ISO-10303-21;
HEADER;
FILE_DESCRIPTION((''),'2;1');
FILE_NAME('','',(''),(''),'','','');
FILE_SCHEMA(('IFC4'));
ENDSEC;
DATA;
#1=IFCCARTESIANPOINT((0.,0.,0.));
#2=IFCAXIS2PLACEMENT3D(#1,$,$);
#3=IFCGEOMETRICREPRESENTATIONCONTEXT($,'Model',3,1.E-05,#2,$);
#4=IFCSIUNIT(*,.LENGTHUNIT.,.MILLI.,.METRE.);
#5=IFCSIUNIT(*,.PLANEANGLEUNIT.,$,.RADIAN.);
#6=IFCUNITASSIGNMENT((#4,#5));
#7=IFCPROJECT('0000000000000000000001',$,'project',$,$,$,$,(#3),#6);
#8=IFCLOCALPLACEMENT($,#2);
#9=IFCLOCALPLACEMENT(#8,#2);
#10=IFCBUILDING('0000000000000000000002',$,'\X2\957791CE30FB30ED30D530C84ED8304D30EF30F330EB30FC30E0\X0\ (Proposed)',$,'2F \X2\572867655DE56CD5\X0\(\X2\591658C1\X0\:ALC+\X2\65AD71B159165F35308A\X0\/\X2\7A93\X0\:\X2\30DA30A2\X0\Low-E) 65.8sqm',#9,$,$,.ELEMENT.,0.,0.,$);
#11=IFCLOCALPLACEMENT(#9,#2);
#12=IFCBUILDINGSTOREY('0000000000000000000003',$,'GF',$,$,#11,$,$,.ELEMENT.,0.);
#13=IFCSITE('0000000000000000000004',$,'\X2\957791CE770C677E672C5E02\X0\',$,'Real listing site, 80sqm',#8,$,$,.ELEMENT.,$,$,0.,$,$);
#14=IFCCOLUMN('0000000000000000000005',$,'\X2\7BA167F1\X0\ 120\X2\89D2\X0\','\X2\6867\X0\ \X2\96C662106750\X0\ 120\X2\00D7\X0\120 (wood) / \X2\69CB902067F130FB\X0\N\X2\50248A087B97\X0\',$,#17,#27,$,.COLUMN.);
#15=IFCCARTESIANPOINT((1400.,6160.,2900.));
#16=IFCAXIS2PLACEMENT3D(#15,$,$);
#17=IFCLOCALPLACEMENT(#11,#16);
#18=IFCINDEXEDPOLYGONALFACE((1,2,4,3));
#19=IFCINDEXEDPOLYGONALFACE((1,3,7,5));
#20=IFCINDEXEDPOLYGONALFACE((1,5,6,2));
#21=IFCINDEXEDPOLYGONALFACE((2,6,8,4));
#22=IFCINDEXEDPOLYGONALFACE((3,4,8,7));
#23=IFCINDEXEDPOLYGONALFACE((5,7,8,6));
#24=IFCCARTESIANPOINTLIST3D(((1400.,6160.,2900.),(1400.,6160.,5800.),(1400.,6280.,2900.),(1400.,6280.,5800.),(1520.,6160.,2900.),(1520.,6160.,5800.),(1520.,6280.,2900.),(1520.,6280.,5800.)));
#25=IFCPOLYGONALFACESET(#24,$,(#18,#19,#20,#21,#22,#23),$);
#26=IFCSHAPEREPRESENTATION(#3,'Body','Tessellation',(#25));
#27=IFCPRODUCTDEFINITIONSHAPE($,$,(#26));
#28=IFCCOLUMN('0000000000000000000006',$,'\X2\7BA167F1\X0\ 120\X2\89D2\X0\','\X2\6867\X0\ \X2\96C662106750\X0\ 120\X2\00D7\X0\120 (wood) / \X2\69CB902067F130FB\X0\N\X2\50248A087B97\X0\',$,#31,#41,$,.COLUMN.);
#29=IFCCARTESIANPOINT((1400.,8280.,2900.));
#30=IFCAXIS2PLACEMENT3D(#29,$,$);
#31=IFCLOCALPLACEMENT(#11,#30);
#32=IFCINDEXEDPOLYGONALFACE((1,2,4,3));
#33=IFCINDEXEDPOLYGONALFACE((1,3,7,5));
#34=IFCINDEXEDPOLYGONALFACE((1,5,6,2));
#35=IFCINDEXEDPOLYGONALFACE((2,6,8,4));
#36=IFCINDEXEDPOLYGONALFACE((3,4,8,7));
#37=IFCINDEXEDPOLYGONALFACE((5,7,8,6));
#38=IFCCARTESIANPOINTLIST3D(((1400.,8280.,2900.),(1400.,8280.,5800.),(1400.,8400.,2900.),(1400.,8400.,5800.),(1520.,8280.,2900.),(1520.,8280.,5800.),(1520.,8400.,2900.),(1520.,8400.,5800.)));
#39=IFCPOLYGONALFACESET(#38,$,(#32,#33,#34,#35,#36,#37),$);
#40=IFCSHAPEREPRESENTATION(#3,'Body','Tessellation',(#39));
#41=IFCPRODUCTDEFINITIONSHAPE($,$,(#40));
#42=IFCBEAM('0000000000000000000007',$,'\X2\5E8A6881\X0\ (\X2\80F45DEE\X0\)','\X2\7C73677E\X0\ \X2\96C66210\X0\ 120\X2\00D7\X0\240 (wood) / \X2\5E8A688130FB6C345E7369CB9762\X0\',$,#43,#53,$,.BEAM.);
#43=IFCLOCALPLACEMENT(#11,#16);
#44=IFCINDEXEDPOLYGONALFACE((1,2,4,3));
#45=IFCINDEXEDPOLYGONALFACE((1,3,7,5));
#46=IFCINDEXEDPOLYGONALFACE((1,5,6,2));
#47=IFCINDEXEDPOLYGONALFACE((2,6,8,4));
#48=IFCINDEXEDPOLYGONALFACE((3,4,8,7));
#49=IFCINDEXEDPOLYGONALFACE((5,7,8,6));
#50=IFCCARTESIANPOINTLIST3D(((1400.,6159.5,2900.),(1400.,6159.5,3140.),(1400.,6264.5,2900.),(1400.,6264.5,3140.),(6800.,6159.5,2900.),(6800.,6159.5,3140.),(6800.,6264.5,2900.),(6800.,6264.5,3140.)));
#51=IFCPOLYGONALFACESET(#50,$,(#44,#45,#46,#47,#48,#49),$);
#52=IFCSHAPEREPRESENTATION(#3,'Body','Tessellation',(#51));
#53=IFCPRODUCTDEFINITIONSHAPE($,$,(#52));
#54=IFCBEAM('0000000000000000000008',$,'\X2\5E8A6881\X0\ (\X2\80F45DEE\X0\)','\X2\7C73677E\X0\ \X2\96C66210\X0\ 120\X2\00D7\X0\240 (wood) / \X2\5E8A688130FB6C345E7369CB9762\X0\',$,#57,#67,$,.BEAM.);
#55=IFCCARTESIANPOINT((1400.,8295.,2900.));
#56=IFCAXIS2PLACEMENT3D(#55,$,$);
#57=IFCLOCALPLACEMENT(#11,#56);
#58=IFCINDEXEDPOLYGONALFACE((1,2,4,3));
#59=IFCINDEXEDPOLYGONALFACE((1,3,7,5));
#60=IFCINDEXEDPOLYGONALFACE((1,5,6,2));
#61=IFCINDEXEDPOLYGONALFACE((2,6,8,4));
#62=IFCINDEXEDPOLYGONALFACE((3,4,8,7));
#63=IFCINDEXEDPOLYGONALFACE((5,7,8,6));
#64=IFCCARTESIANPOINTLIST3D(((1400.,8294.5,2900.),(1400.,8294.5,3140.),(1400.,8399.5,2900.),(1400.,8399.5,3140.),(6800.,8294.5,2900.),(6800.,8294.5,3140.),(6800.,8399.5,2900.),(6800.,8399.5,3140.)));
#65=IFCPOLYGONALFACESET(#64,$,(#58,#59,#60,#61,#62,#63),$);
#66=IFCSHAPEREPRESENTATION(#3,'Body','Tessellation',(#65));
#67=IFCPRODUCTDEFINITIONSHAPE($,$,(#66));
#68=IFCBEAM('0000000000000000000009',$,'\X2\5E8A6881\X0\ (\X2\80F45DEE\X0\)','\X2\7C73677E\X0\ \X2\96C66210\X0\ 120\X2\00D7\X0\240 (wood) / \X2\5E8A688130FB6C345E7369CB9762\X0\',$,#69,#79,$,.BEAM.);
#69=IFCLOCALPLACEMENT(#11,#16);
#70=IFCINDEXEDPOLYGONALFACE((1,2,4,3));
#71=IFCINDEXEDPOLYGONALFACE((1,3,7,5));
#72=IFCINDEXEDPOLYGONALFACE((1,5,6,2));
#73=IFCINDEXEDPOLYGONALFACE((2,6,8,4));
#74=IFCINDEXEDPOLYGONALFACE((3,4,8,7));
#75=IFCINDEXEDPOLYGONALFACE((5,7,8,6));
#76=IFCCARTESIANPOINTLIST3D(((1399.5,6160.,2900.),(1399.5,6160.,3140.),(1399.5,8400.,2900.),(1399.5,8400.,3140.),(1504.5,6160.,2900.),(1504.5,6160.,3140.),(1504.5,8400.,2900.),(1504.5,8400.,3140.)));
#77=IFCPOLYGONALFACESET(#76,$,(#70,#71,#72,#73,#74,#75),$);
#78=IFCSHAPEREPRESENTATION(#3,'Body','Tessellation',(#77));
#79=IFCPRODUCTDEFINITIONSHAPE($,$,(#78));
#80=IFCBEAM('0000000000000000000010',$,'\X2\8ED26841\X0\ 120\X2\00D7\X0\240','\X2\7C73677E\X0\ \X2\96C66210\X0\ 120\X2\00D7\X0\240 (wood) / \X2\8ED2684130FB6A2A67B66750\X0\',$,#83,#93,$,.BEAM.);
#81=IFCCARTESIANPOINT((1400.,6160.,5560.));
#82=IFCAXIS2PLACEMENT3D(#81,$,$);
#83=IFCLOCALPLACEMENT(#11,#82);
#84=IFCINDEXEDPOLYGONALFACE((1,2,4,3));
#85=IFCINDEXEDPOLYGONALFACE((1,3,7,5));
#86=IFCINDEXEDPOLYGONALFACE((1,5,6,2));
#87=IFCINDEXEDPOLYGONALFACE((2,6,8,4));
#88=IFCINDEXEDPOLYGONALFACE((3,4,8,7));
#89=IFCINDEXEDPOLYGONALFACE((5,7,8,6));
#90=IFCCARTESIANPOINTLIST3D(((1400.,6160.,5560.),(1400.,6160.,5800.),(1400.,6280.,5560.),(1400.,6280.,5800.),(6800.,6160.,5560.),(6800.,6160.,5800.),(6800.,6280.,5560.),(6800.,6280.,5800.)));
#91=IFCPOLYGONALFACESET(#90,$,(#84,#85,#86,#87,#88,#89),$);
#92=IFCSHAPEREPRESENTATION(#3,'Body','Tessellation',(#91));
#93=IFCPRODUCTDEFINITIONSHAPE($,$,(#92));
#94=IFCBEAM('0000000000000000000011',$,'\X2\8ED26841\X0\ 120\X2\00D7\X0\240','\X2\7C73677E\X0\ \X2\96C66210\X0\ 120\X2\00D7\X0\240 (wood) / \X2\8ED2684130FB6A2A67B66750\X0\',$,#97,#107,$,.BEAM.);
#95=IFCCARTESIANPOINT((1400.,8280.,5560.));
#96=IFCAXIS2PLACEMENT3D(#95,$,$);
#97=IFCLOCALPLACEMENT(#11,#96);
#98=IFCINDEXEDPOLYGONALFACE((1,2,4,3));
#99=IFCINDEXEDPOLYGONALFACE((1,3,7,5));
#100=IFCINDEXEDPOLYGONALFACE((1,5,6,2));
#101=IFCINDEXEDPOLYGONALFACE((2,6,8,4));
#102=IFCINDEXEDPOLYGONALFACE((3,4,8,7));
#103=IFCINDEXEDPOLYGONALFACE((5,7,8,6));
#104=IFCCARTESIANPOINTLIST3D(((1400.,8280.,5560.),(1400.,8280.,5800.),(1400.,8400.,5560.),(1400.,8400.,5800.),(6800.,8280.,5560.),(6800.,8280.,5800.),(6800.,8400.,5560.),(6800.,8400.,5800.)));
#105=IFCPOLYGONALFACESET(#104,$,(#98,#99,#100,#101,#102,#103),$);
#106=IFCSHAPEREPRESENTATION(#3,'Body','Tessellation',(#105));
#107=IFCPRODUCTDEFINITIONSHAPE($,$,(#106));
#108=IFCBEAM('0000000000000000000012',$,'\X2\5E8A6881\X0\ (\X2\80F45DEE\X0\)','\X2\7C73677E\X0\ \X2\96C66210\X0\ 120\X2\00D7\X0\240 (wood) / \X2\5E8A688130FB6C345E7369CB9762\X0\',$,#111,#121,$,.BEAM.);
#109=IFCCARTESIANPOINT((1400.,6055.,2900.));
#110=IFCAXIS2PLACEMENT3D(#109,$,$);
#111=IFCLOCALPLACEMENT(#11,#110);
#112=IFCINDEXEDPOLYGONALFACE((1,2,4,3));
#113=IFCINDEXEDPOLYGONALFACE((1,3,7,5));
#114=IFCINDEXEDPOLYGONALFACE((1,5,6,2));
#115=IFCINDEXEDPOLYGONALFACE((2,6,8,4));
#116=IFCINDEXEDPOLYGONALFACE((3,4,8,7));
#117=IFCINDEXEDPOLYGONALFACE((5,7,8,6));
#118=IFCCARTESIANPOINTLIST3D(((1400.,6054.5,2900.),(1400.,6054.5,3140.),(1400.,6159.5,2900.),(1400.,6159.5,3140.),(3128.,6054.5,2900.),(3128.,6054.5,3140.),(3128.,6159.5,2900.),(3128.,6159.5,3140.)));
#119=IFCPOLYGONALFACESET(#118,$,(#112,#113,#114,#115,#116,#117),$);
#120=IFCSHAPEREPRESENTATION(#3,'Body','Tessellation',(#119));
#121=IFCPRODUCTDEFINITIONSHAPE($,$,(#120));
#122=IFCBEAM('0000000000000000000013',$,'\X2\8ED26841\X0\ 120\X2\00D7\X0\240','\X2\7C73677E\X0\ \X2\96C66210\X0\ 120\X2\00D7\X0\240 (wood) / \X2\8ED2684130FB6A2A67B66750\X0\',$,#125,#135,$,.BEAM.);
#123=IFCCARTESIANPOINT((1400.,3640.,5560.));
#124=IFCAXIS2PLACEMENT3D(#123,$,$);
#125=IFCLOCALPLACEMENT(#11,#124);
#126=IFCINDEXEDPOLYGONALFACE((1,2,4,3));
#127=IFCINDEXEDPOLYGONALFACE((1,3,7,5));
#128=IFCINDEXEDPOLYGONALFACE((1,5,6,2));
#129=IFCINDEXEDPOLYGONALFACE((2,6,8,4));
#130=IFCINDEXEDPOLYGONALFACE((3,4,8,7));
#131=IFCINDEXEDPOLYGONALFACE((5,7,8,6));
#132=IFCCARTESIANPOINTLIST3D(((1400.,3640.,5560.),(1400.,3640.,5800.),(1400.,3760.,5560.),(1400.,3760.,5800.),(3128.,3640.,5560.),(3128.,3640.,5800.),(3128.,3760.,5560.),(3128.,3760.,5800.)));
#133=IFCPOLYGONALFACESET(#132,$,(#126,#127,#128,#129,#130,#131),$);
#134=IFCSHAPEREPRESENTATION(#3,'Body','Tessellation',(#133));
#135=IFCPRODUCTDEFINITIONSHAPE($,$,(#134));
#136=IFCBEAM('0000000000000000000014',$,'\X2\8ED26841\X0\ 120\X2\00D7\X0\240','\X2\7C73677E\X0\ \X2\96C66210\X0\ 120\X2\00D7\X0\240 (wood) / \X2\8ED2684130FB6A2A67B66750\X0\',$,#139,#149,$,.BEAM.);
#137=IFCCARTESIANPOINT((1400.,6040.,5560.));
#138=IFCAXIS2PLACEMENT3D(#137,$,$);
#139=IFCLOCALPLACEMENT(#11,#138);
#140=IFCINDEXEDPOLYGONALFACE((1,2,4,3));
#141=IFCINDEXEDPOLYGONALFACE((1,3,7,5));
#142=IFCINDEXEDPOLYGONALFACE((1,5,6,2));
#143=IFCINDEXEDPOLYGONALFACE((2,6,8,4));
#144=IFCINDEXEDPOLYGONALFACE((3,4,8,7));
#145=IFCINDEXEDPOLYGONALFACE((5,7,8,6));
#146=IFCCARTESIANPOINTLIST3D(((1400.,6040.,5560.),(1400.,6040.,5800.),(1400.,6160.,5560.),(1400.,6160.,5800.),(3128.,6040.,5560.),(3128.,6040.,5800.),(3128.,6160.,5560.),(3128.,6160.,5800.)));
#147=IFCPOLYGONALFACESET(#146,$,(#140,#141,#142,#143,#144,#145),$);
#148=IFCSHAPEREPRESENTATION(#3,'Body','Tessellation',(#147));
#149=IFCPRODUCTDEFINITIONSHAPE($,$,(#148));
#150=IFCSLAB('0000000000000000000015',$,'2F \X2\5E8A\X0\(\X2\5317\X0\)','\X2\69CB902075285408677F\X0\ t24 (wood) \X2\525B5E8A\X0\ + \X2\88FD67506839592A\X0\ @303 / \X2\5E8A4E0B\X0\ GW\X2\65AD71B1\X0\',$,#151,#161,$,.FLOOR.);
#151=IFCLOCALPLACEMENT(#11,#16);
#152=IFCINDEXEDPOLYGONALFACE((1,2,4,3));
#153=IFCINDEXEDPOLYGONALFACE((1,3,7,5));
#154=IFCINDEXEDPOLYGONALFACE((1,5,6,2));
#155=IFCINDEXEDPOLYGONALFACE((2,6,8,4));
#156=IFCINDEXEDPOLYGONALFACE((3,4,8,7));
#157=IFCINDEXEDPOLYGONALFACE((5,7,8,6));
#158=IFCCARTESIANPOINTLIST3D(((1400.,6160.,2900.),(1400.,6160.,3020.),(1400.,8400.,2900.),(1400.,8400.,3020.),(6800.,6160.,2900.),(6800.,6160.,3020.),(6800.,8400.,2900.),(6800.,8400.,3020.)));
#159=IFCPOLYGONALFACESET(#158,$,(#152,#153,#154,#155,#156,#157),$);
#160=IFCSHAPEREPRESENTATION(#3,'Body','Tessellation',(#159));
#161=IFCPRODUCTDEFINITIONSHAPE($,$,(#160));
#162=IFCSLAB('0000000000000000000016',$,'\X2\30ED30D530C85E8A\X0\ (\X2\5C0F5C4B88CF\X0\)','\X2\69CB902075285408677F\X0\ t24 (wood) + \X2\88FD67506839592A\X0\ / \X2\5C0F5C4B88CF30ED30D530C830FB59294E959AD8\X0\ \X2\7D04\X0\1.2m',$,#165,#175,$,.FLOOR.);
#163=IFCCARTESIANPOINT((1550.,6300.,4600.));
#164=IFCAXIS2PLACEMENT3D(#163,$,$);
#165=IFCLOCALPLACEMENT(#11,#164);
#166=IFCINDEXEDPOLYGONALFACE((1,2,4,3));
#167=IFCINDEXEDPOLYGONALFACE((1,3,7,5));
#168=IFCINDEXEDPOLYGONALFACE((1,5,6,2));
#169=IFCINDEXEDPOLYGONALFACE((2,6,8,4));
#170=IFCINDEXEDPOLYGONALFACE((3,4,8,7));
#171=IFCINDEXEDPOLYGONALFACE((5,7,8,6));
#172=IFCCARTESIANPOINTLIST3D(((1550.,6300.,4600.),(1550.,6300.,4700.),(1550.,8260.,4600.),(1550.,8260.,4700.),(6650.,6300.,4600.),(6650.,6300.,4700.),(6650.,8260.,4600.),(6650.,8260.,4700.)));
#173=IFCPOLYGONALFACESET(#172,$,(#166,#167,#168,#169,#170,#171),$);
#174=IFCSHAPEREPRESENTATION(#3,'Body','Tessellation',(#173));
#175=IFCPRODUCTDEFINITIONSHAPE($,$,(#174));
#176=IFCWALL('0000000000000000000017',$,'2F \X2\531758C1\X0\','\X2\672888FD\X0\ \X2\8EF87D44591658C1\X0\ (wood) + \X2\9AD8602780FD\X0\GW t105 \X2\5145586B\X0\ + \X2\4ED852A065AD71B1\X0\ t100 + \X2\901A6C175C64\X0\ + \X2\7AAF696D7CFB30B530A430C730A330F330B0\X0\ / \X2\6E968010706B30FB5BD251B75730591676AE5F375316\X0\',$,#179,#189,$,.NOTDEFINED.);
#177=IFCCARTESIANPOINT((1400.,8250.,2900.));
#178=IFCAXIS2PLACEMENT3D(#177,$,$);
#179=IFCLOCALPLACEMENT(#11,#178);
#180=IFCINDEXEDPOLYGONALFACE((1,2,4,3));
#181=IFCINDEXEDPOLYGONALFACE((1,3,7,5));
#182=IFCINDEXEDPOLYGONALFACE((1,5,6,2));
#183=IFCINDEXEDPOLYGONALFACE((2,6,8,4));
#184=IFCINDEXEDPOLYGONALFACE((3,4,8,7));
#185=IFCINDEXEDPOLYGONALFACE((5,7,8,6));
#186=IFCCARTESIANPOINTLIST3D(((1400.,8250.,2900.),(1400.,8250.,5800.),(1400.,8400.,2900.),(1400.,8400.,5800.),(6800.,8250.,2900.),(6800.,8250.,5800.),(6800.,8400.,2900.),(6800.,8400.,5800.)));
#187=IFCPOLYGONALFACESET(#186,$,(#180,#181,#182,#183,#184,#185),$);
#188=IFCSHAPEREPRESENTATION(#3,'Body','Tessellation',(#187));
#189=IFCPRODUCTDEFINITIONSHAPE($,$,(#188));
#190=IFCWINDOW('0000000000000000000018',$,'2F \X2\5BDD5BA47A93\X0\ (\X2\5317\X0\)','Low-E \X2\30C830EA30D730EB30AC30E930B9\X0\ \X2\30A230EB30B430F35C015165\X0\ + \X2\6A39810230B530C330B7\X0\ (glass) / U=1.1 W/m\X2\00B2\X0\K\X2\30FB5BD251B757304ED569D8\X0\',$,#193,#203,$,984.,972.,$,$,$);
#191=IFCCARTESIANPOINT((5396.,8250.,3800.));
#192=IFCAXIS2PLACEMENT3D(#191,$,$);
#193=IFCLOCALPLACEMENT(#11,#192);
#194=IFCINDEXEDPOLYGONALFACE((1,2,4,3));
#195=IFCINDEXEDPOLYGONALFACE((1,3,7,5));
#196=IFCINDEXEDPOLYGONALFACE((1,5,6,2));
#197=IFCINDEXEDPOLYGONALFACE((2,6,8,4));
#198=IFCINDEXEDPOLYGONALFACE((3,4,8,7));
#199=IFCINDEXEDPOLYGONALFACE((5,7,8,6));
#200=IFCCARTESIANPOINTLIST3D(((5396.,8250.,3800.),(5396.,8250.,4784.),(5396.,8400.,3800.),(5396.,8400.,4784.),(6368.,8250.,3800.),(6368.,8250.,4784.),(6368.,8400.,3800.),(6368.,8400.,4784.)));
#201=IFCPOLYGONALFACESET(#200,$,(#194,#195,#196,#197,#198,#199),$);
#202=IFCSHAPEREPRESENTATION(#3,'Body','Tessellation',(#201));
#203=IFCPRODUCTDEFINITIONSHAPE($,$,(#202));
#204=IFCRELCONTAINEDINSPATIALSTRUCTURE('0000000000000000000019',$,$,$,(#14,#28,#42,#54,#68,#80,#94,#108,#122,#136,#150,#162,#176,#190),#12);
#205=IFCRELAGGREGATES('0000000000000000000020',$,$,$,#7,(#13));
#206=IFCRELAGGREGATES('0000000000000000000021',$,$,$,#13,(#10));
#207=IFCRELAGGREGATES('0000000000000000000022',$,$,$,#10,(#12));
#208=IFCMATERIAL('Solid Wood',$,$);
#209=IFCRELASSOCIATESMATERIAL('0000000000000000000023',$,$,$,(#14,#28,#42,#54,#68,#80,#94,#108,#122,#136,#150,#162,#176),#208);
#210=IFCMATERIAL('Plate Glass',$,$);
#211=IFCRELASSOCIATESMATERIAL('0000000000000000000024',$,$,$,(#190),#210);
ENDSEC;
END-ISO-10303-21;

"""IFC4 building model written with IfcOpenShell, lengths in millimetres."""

from ifc_helpers import new_model, si_unit, frame, frame_2d, origin, place, context, project, spatial, rectangle, extrude, material, element, fill, save


model = new_model("IFC4")

# Units and contexts
model_context = context("Model", 3, precision=1e-05, world=origin())
ifc_project = project(units=[si_unit("LENGTHUNIT", "METRE", prefix="MILLI"), si_unit("PLANEANGLEUNIT", "RADIAN")], contexts=[model_context])

# Site, building, storey
site_placement = place(None, origin())
site = spatial("IfcSite", under=ifc_project, at=site_placement, Name="長野県松本市", ObjectType="Real listing site, 80sqm", CompositionType="ELEMENT", RefElevation=0.0)
building_placement = place(site_placement, origin())
building = spatial("IfcBuilding", under=site, at=building_placement, Name="長野・ロフト付きワンルーム (Proposed)", ObjectType="2F 在来工法(外壁:ALC+断熱外張り/窓:ペアLow-E) 65.8sqm", CompositionType="ELEMENT", ElevationOfRefHeight=0.0, ElevationOfTerrain=0.0)
storey_placement = place(building_placement, origin())
storey = spatial("IfcBuildingStorey", under=building, at=storey_placement, Name="GF", CompositionType="ELEMENT", Elevation=0.0)

# Columns
ifc_material_1 = material(Name="Solid Wood")
column_1_placement = place(storey_placement, frame((1400.0, 6160.0, 2900.0)))
element("IfcColumn", 1, at=column_1_placement, inside=storey, material=ifc_material_1, Name="管柱 120角", Description="桧 集成材 120×120 (wood) / 構造柱・N値計算", PredefinedType="COLUMN", context=model_context, shape_type="SweptSolid", body=[
    extrude(rectangle(XDim=120.0, YDim=120.0, at=frame_2d((60.0, 60.0))), frame((1400.0, 6160.0, 2900.0)), (0.0, 0.0, 1.0), 2900.0),
])
column_2_placement = place(storey_placement, frame((1400.0, 8280.0, 2900.0)))
element("IfcColumn", 2, at=column_2_placement, inside=storey, material=ifc_material_1, Name="管柱 120角", Description="桧 集成材 120×120 (wood) / 構造柱・N値計算", PredefinedType="COLUMN", context=model_context, shape_type="SweptSolid", body=[
    extrude(rectangle(XDim=120.0, YDim=120.0, at=frame_2d((60.0, 60.0))), frame((1400.0, 8280.0, 2900.0)), (0.0, 0.0, 1.0), 2900.0),
])

# Beams
beam_1_placement = place(storey_placement, frame((1400.0, 6160.0, 2900.0)))
element("IfcBeam", 3, at=beam_1_placement, inside=storey, material=ifc_material_1, Name="床梁 (胴差)", Description="米松 集成 120×240 (wood) / 床梁・水平構面", PredefinedType="BEAM", context=model_context, shape_type="SweptSolid", body=[
    extrude(rectangle(XDim=5400.0, YDim=105.0, at=frame_2d((2700.0, 52.0))), frame((1400.0, 6160.0, 2900.0)), (0.0, 0.0, 1.0), 240.0),
])
beam_2_placement = place(storey_placement, frame((1400.0, 8295.0, 2900.0)))
element("IfcBeam", 4, at=beam_2_placement, inside=storey, material=ifc_material_1, Name="床梁 (胴差)", Description="米松 集成 120×240 (wood) / 床梁・水平構面", PredefinedType="BEAM", context=model_context, shape_type="SweptSolid", body=[
    extrude(rectangle(XDim=5400.0, YDim=105.0, at=frame_2d((2700.0, 52.0))), frame((1400.0, 8295.0, 2900.0)), (0.0, 0.0, 1.0), 240.0),
])
beam_3_placement = place(storey_placement, frame((1400.0, 6160.0, 2900.0)))
element("IfcBeam", 5, at=beam_3_placement, inside=storey, material=ifc_material_1, Name="床梁 (胴差)", Description="米松 集成 120×240 (wood) / 床梁・水平構面", PredefinedType="BEAM", context=model_context, shape_type="SweptSolid", body=[
    extrude(rectangle(XDim=105.0, YDim=2240.0, at=frame_2d((52.0, 1120.0))), frame((1400.0, 6160.0, 2900.0)), (0.0, 0.0, 1.0), 240.0),
])
beam_4_placement = place(storey_placement, frame((1400.0, 6160.0, 5560.0)))
element("IfcBeam", 6, at=beam_4_placement, inside=storey, material=ifc_material_1, Name="軒桁 120×240", Description="米松 集成 120×240 (wood) / 軒桁・横架材", PredefinedType="BEAM", context=model_context, shape_type="SweptSolid", body=[
    extrude(rectangle(XDim=5400.0, YDim=120.0, at=frame_2d((2700.0, 60.0))), frame((1400.0, 6160.0, 5560.0)), (0.0, 0.0, 1.0), 240.0),
])
beam_5_placement = place(storey_placement, frame((1400.0, 8280.0, 5560.0)))
element("IfcBeam", 7, at=beam_5_placement, inside=storey, material=ifc_material_1, Name="軒桁 120×240", Description="米松 集成 120×240 (wood) / 軒桁・横架材", PredefinedType="BEAM", context=model_context, shape_type="SweptSolid", body=[
    extrude(rectangle(XDim=5400.0, YDim=120.0, at=frame_2d((2700.0, 60.0))), frame((1400.0, 8280.0, 5560.0)), (0.0, 0.0, 1.0), 240.0),
])
beam_6_placement = place(storey_placement, frame((1400.0, 6055.0, 2900.0)))
element("IfcBeam", 8, at=beam_6_placement, inside=storey, material=ifc_material_1, Name="床梁 (胴差)", Description="米松 集成 120×240 (wood) / 床梁・水平構面", PredefinedType="BEAM", context=model_context, shape_type="SweptSolid", body=[
    extrude(rectangle(XDim=1728.0, YDim=105.0, at=frame_2d((864.0, 52.0))), frame((1400.0, 6055.0, 2900.0)), (0.0, 0.0, 1.0), 240.0),
])
beam_7_placement = place(storey_placement, frame((1400.0, 3640.0, 5560.0)))
element("IfcBeam", 9, at=beam_7_placement, inside=storey, material=ifc_material_1, Name="軒桁 120×240", Description="米松 集成 120×240 (wood) / 軒桁・横架材", PredefinedType="BEAM", context=model_context, shape_type="SweptSolid", body=[
    extrude(rectangle(XDim=1728.0, YDim=120.0, at=frame_2d((864.0, 60.0))), frame((1400.0, 3640.0, 5560.0)), (0.0, 0.0, 1.0), 240.0),
])
beam_8_placement = place(storey_placement, frame((1400.0, 6040.0, 5560.0)))
element("IfcBeam", 10, at=beam_8_placement, inside=storey, material=ifc_material_1, Name="軒桁 120×240", Description="米松 集成 120×240 (wood) / 軒桁・横架材", PredefinedType="BEAM", context=model_context, shape_type="SweptSolid", body=[
    extrude(rectangle(XDim=1728.0, YDim=120.0, at=frame_2d((864.0, 60.0))), frame((1400.0, 6040.0, 5560.0)), (0.0, 0.0, 1.0), 240.0),
])

# Slabs
slab_1_placement = place(storey_placement, frame((1400.0, 6160.0, 2900.0)))
element("IfcSlab", 11, at=slab_1_placement, inside=storey, material=ifc_material_1, Name="2F 床(北)", Description="構造用合板 t24 (wood) 剛床 + 製材根太 @303 / 床下 GW断熱", PredefinedType="FLOOR", context=model_context, shape_type="SweptSolid", body=[
    extrude(rectangle(XDim=5400.0, YDim=2240.0, at=frame_2d((2700.0, 1120.0))), frame((1400.0, 6160.0, 2900.0)), (0.0, 0.0, 1.0), 120.0),
])
slab_2_placement = place(storey_placement, frame((1550.0, 6300.0, 4600.0)))
element("IfcSlab", 12, at=slab_2_placement, inside=storey, material=ifc_material_1, Name="ロフト床 (小屋裏)", Description="構造用合板 t24 (wood) + 製材根太 / 小屋裏ロフト・天井高 約1.2m", PredefinedType="FLOOR", context=model_context, shape_type="SweptSolid", body=[
    extrude(rectangle(XDim=5100.0, YDim=1960.0, at=frame_2d((2550.0, 980.0))), frame((1550.0, 6300.0, 4600.0)), (0.0, 0.0, 1.0), 100.0),
])

# Wall, opening, window
wall_placement = place(storey_placement, frame((1400.0, 8250.0, 2900.0)))
wall = element("IfcWall", 13, at=wall_placement, inside=storey, material=ifc_material_1, Name="2F 北壁", Description="木製 軸組外壁 (wood) + 高性能GW t105 充填 + 付加断熱 t100 + 通気層 + 窯業系サイディング / 準耐火・寒冷地外皮強化", PredefinedType="NOTDEFINED", context=model_context, shape_type="SweptSolid", body=[
    extrude(rectangle(XDim=5400.0, YDim=150.0, at=frame_2d((2700.0, 75.0))), frame((1400.0, 8250.0, 2900.0)), (0.0, 0.0, 1.0), 2900.0),
])
opening_placement = place(storey_placement, frame((5396.0, 8250.0, 3800.0)))
opening = element("IfcOpeningElement", 14, at=opening_placement, cuts=wall, PredefinedType="NOTDEFINED", context=model_context, shape_type="SweptSolid", body=[
    extrude(rectangle(XDim=972.0, YDim=150.0, at=frame_2d((486.0, 75.0))), frame((5396.0, 8250.0, 3800.0)), (0.0, 0.0, 1.0), 984.0),
])
ifc_material_2 = material(Name="Plate Glass")
window_placement = place(storey_placement, frame((5396.0, 8250.0, 3800.0)))
window = element("IfcWindow", 15, at=window_placement, inside=storey, material=ifc_material_2, Name="2F 寝室窓 (北)", Description="Low-E トリプルガラス アルゴン封入 + 樹脂サッシ (glass) / U=1.1 W/m²K・寒冷地仕様", OverallHeight=984.0, OverallWidth=972.0, context=model_context, shape_type="SweptSolid", body=[
    extrude(rectangle(XDim=972.0, YDim=150.0, at=frame_2d((486.0, 75.0))), frame((5396.0, 8250.0, 3800.0)), (0.0, 0.0, 1.0), 984.0),
])
fill(opening, window)

save(model, "model.ifc")
